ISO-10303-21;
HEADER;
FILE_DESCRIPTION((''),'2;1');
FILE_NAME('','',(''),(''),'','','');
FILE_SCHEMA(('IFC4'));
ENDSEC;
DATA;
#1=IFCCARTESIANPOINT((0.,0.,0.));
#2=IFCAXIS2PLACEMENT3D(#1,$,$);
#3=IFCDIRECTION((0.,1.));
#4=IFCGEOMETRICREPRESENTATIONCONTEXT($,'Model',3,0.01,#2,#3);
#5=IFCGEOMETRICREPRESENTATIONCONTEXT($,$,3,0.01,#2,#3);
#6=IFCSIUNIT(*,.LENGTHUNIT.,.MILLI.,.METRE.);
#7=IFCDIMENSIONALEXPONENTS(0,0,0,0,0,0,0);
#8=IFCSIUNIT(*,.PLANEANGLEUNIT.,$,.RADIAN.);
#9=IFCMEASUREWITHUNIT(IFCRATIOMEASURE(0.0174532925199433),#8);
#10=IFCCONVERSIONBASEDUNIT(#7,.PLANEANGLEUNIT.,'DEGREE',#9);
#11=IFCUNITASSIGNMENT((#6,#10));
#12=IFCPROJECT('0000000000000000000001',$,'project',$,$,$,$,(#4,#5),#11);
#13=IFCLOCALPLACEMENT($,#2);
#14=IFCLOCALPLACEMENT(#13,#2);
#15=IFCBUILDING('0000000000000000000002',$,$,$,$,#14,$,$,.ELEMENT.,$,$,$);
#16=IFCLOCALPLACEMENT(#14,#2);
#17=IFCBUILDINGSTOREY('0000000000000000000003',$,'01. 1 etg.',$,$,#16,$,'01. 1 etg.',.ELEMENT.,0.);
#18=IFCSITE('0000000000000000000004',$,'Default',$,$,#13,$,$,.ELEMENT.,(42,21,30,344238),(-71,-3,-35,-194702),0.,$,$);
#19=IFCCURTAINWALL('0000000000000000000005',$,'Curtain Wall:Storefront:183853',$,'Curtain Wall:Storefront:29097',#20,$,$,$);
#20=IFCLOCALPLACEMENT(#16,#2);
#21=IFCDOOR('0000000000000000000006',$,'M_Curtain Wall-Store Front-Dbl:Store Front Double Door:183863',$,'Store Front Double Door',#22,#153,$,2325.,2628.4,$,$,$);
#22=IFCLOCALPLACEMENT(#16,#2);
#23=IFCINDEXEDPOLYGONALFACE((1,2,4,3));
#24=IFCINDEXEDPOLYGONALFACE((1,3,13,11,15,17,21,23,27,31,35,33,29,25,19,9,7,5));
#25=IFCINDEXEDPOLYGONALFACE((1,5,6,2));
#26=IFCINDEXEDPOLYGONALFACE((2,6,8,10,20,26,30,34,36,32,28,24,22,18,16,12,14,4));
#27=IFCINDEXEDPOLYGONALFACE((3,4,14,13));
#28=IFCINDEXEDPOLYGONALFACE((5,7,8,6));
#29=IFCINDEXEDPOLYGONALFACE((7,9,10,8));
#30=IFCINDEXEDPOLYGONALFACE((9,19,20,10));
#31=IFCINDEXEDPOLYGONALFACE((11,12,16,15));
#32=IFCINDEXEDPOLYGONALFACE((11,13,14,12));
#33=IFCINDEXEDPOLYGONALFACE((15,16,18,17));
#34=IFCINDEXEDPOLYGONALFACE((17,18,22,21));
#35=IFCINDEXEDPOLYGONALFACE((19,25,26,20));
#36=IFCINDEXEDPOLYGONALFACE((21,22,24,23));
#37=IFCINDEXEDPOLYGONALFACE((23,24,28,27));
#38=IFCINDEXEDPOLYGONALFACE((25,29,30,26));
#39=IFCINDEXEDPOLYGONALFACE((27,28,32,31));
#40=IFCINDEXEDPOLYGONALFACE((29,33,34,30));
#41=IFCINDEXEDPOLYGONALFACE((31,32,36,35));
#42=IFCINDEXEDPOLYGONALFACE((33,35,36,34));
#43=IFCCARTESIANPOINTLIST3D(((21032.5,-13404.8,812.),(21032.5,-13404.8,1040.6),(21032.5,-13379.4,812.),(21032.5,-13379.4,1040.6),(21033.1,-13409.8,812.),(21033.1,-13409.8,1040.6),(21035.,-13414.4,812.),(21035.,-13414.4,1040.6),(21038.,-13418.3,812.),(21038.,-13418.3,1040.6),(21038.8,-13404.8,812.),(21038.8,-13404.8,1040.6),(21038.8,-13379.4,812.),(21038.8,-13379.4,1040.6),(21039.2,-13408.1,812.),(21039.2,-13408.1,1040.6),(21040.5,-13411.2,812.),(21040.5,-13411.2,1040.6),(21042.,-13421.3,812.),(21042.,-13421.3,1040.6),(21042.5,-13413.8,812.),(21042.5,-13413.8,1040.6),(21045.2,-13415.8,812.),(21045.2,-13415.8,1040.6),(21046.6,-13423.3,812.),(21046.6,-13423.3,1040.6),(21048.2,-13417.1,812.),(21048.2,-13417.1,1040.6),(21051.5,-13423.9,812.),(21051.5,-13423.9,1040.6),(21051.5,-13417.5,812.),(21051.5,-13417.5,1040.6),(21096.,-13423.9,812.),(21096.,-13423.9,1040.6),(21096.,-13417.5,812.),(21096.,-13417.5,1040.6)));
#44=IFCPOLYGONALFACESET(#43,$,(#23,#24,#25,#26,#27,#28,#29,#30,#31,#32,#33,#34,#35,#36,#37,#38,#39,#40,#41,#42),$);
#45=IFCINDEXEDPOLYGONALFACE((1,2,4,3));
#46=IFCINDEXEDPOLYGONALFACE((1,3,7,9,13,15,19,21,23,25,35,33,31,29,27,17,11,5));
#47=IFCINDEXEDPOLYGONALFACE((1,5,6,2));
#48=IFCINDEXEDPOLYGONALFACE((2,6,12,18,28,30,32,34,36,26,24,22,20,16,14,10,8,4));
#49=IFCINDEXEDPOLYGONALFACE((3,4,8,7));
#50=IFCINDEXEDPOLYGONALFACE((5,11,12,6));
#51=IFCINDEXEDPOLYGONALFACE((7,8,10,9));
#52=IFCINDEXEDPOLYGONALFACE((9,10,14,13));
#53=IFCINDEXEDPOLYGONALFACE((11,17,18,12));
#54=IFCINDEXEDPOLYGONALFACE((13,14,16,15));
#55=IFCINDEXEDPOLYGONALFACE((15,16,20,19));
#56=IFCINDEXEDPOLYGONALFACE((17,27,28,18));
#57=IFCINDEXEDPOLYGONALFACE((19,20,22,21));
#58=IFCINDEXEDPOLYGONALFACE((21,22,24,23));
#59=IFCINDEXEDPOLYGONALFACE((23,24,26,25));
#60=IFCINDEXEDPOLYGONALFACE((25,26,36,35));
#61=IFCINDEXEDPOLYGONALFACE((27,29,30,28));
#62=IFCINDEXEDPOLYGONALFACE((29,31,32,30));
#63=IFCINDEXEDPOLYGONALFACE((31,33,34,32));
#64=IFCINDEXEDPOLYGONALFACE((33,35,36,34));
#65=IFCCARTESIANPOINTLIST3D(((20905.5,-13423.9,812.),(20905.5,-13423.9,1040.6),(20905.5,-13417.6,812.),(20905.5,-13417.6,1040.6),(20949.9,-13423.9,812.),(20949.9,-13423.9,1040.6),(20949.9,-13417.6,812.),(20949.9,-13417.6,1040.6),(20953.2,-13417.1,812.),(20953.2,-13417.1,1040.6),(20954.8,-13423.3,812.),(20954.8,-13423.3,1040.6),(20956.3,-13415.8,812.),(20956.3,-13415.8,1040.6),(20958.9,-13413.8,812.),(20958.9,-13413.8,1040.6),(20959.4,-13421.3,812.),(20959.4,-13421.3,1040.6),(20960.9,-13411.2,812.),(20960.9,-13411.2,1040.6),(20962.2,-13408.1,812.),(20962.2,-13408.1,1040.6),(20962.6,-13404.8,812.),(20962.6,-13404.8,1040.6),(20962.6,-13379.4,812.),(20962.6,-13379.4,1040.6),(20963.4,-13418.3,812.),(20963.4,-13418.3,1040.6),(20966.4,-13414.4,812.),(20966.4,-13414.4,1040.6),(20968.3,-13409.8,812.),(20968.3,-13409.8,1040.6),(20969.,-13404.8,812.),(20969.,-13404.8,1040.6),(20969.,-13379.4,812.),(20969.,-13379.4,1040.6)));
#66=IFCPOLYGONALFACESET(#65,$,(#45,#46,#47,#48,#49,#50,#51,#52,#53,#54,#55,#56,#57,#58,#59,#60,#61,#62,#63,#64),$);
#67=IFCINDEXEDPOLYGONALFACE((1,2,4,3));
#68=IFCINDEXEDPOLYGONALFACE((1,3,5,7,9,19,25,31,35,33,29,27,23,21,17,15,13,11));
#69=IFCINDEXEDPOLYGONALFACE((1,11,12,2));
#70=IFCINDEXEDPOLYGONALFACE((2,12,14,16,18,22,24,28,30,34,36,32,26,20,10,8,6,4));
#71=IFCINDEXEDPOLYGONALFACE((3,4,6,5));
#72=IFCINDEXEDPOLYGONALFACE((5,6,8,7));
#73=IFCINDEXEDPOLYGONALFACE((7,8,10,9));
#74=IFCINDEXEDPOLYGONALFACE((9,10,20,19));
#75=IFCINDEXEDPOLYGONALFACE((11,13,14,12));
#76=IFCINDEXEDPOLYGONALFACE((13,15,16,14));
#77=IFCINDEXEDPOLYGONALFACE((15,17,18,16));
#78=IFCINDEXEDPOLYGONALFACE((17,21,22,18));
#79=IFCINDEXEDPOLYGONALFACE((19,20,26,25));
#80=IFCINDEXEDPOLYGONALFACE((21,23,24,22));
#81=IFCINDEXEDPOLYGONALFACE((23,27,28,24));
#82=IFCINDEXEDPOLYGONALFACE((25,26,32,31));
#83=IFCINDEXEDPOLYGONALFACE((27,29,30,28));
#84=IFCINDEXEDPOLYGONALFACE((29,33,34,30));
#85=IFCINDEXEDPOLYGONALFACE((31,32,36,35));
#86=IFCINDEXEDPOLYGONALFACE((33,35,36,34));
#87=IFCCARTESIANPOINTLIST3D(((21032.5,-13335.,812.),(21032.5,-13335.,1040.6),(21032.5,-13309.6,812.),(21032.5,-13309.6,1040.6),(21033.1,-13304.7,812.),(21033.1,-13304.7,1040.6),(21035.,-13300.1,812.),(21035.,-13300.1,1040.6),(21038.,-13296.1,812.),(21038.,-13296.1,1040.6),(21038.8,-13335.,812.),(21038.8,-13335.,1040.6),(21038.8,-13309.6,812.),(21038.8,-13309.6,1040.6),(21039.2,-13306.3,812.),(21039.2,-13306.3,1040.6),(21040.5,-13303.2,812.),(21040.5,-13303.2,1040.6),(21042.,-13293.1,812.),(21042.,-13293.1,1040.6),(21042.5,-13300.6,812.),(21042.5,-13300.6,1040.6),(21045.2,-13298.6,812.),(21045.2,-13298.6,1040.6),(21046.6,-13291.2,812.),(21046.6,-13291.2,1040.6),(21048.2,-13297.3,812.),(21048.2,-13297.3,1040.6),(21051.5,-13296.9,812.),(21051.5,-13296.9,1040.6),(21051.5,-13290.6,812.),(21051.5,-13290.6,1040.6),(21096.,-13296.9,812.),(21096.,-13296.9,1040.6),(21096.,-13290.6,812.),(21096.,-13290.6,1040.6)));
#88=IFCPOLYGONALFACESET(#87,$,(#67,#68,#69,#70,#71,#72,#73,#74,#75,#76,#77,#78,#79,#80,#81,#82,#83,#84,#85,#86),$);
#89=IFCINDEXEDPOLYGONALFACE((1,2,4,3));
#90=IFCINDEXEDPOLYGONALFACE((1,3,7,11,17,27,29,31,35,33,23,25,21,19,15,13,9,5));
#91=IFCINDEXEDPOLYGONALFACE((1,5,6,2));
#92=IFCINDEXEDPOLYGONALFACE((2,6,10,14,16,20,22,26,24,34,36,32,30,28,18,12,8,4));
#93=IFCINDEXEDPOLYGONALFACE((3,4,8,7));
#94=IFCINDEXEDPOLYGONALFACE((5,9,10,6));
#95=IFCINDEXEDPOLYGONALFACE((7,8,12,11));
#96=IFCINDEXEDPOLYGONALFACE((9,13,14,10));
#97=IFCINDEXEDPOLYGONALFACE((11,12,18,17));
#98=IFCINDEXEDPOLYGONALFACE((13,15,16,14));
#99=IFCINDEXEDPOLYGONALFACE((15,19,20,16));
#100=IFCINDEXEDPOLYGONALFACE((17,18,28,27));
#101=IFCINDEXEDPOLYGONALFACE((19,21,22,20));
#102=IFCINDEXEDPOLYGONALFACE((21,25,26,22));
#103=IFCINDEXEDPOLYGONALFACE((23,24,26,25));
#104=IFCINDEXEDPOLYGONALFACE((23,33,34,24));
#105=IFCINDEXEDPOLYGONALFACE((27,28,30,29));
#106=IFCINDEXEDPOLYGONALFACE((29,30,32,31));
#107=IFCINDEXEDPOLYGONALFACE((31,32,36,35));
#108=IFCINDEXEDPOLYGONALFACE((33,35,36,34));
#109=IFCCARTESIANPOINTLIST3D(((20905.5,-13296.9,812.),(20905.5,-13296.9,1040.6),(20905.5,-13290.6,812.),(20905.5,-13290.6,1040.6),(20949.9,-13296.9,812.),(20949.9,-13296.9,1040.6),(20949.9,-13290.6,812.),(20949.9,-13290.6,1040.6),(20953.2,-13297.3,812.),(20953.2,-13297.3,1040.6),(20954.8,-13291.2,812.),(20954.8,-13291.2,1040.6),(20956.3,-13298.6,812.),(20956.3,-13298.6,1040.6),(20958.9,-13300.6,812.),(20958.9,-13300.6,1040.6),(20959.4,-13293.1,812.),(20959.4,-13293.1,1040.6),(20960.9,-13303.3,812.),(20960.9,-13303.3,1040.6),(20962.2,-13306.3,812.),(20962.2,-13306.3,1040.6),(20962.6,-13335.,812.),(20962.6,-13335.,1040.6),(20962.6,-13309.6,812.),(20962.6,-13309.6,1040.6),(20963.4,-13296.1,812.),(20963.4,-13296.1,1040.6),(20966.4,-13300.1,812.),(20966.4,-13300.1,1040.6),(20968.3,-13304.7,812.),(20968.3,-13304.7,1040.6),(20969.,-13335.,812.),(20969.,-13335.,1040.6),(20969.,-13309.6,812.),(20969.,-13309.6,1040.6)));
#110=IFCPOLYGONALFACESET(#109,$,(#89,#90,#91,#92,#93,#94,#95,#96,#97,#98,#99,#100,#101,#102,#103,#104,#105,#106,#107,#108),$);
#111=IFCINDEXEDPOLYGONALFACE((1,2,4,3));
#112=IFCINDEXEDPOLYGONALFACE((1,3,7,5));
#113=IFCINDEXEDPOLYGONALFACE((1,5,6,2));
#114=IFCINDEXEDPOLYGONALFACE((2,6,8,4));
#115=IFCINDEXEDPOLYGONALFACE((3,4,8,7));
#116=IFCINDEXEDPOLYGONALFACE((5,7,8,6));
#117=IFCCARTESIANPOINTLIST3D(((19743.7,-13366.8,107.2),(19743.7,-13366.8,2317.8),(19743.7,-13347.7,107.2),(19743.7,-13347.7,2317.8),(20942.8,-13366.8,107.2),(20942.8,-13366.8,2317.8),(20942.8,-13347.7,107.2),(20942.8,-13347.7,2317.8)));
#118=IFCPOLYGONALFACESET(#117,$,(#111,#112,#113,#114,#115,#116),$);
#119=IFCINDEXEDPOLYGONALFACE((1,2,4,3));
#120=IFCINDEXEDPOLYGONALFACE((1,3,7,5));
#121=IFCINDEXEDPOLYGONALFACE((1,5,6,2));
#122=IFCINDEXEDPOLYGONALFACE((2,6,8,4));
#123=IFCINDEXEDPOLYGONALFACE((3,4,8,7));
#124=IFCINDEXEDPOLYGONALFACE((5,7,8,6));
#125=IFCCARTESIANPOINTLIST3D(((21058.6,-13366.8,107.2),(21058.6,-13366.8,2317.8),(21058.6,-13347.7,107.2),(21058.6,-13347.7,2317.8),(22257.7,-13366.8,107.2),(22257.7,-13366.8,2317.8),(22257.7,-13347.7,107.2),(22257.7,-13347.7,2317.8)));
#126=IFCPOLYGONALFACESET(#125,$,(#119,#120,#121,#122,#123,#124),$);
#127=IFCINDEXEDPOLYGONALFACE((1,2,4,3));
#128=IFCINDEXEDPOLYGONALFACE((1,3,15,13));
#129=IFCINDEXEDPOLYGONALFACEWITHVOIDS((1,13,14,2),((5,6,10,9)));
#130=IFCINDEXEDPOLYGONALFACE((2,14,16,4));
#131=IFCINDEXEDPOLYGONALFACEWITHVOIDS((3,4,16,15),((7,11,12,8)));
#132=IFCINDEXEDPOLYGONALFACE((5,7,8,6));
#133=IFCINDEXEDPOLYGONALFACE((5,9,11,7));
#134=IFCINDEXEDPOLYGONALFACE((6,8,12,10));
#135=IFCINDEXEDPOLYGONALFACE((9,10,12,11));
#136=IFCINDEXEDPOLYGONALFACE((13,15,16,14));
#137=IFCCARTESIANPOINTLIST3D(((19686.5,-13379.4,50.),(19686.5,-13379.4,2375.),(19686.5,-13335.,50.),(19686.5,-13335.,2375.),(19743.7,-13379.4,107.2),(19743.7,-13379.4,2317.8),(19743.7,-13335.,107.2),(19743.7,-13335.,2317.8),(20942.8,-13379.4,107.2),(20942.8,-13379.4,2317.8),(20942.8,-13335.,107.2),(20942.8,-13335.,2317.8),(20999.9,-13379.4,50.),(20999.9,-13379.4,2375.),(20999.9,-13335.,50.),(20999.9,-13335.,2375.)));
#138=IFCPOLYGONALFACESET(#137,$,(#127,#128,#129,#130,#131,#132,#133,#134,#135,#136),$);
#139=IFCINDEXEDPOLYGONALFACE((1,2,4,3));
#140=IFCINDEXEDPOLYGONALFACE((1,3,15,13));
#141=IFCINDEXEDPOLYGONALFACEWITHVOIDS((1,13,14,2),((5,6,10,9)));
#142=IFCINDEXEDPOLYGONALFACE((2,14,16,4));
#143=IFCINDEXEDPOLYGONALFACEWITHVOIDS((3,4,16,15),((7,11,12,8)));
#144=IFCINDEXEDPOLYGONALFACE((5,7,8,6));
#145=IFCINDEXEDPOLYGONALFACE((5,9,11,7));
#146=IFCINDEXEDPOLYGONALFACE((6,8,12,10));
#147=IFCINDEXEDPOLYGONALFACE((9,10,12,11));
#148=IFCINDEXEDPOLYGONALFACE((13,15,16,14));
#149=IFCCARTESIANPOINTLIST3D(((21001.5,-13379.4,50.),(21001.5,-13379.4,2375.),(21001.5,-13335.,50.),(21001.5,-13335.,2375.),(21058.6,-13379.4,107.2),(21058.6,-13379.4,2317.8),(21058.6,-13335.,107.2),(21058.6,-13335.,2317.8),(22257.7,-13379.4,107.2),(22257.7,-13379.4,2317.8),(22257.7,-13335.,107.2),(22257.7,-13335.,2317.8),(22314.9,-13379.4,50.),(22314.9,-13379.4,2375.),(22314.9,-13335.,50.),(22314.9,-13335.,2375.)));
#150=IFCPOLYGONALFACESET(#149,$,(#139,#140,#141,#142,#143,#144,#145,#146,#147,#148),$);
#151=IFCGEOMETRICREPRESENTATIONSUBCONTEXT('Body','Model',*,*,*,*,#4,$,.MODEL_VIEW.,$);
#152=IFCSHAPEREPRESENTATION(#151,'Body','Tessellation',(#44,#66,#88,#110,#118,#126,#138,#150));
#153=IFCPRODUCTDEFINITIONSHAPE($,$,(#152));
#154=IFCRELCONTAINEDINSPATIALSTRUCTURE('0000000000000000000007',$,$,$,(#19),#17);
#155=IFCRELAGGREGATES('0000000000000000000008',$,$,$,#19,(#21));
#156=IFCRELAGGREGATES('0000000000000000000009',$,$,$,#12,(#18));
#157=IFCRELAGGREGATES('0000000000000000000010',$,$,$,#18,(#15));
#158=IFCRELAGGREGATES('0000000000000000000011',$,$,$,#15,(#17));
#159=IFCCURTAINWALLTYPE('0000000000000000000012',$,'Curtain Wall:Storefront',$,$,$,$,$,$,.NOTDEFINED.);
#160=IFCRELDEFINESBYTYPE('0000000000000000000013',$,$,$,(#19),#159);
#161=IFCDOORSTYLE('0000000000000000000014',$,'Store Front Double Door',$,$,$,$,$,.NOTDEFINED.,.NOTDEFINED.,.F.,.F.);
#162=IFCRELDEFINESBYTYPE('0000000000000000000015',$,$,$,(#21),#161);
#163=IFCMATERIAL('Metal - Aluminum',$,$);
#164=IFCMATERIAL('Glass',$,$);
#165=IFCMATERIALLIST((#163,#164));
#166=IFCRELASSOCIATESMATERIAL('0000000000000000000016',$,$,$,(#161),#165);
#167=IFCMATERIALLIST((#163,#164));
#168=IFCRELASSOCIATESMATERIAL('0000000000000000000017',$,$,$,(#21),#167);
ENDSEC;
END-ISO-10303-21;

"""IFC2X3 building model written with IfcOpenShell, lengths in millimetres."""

from ifc_helpers import new_model, entity, si_unit, converted_unit, direction, frame, frame_2d, origin, place, context, subcontext, project, spatial, polyline, circle_curve, parameter, trimmed, segment, composite_curve, rectangle, outline, extrude, source, transform, mapped, material, material_list, type_object, type_shapes, element, aggregate, save


model = new_model("IFC2X3")

# Units and contexts
model_context = context("Model", 3, precision=0.01, world=origin(), true_north=direction((0.0, 1.0)))
context_of_model = context(None, 3, precision=0.01, world=origin(), true_north=direction((0.0, 1.0)))
body_context = subcontext(model_context, "Body", "Model", "MODEL_VIEW")
ifc_project = project(units=[si_unit("LENGTHUNIT", "METRE", prefix="MILLI"), converted_unit("PLANEANGLEUNIT", "DEGREE", entity("IfcRatioMeasure", 0.0174532925199433), si_unit("PLANEANGLEUNIT", "RADIAN"), dimensions=[0, 0, 0, 0, 0, 0, 0])], contexts=[model_context, context_of_model])

# Site, building, storey
site_placement = place(None, origin())
site = spatial("IfcSite", under=ifc_project, at=site_placement, Name="Default", CompositionType="ELEMENT", RefLatitude=(42, 21, 30, 344238), RefLongitude=(-71, -3, -35, -194702), RefElevation=0.0)
building_placement = place(site_placement, origin())
building = spatial("IfcBuilding", under=site, at=building_placement, CompositionType="ELEMENT")
storey_placement = place(building_placement, origin())
storey = spatial("IfcBuildingStorey", under=building, at=storey_placement, Name="01. 1 etg.", LongName="01. 1 etg.", CompositionType="ELEMENT", Elevation=0.0)

# Curtain wall, door
curtain_wall_type = type_object("IfcCurtainWallType", Name="Curtain Wall:Storefront", PredefinedType="NOTDEFINED")
curtain_wall_placement = place(storey_placement, origin())
curtain_wall = element("IfcCurtainWall", 1, at=curtain_wall_placement, inside=storey, type_object=curtain_wall_type, Name="Curtain Wall:Storefront:183853", ObjectType="Curtain Wall:Storefront:29097")
ifc_material_1 = material(Name="Glass")
ifc_material_2 = material(Name="Metal - Aluminum")
ifc_material_list_1 = material_list([ifc_material_2, ifc_material_1])
ifc_material_list_2 = material_list([ifc_material_2, ifc_material_1])
door_style = type_object("IfcDoorStyle", Name="Store Front Double Door", ConstructionType="NOTDEFINED", OperationType="NOTDEFINED", ParameterTakesPrecedence=False, Sizeable=False, material=ifc_material_list_2)
shared_shape_1 = source(origin(), body_context, "Body", "SweptSolid", [
    extrude(outline(composite_curve([segment(trimmed(circle_curve(frame_2d((-3.2, 1.6), x_axis=(1.0, 0.0)), 19.0), [parameter(180.0)], [parameter(270.0)], True, "PARAMETER"), True, "CONTINUOUS"), segment(polyline([(-3.2, -17.5), (41.3, -17.5)]), True, "CONTINUOUS"), segment(polyline([(41.3, -17.5), (41.3, -11.1)]), True, "CONTINUOUS"), segment(polyline([(41.3, -11.1), (-3.2, -11.1)]), True, "CONTINUOUS"), segment(trimmed(circle_curve(frame_2d((-3.2, 1.6), x_axis=(1.0, 0.0)), 12.7), [parameter(180.0)], [parameter(270.0)], True, "PARAMETER"), False, "CONTINUOUS"), segment(polyline([(-15.9, 1.6), (-15.9, 27.0)]), True, "CONTINUOUS"), segment(polyline([(-15.9, 27.0), (-22.2, 27.0)]), True, "CONTINUOUS"), segment(polyline([(-22.2, 27.0), (-22.2, 1.6)]), True, "CONTINUOUS")], self_intersect=False)), frame((54.0, -16.4, 762.0)), (0.0, 0.0, 1.0), 228.6),
    extrude(outline(composite_curve([segment(polyline([(1.6, -22.2), (27.0, -22.2)]), True, "CONTINUOUS"), segment(polyline([(27.0, -22.2), (27.0, -15.9)]), True, "CONTINUOUS"), segment(polyline([(27.0, -15.9), (1.6, -15.9)]), True, "CONTINUOUS"), segment(trimmed(circle_curve(frame_2d((1.6, -3.2), x_axis=(0.0, -1.0)), 12.7), [parameter(270.0)], [parameter(0.0)], True, "PARAMETER"), False, "CONTINUOUS"), segment(polyline([(-11.1, -3.2), (-11.1, 41.3)]), True, "CONTINUOUS"), segment(polyline([(-11.1, 41.3), (-17.5, 41.3)]), True, "CONTINUOUS"), segment(polyline([(-17.5, 41.3), (-17.5, -3.2)]), True, "CONTINUOUS"), segment(trimmed(circle_curve(frame_2d((1.6, -3.2), x_axis=(0.0, -1.0)), 19.1), [parameter(270.0)], [parameter(360.0)], True, "PARAMETER"), True, "CONTINUOUS")], self_intersect=False)), frame((-54.0, -16.4, 762.0), z_axis=(0.0, 0.0, 1.0), x_axis=(0.0, 1.0, 0.0)), (0.0, 0.0, 1.0), 228.6),
    extrude(outline(composite_curve([segment(polyline([(1.6, -22.2), (27.0, -22.2)]), True, "CONTINUOUS"), segment(polyline([(27.0, -22.2), (27.0, -15.9)]), True, "CONTINUOUS"), segment(polyline([(27.0, -15.9), (1.6, -15.9)]), True, "CONTINUOUS"), segment(trimmed(circle_curve(frame_2d((1.6, -3.2), x_axis=(0.0, 1.0)), 12.7), [parameter(90.0)], [parameter(180.0)], True, "PARAMETER"), False, "CONTINUOUS"), segment(polyline([(-11.1, -3.2), (-11.1, 41.3)]), True, "CONTINUOUS"), segment(polyline([(-11.1, 41.3), (-17.5, 41.3)]), True, "CONTINUOUS"), segment(polyline([(-17.5, 41.3), (-17.5, -3.2)]), True, "CONTINUOUS"), segment(trimmed(circle_curve(frame_2d((1.6, -3.2), x_axis=(0.0, 1.0)), 19.1), [parameter(90.0)], [parameter(180.0)], True, "PARAMETER"), True, "CONTINUOUS")], self_intersect=False)), frame((54.0, 82.0, 762.0), z_axis=(0.0, 0.0, 1.0), x_axis=(0.0, -1.0, 0.0)), (0.0, 0.0, 1.0), 228.6),
    extrude(outline(composite_curve([segment(trimmed(circle_curve(frame_2d((3.2, -1.6), x_axis=(1.0, 0.0)), 19.0), [parameter(0.0)], [parameter(90.0)], True, "PARAMETER"), True, "CONTINUOUS"), segment(polyline([(3.2, 17.5), (-41.3, 17.5)]), True, "CONTINUOUS"), segment(polyline([(-41.3, 17.5), (-41.3, 11.1)]), True, "CONTINUOUS"), segment(polyline([(-41.3, 11.1), (3.2, 11.1)]), True, "CONTINUOUS"), segment(trimmed(circle_curve(frame_2d((3.2, -1.6), x_axis=(1.0, 0.0)), 12.7), [parameter(0.0)], [parameter(90.0)], True, "PARAMETER"), False, "CONTINUOUS"), segment(polyline([(15.9, -1.6), (15.9, -27.0)]), True, "CONTINUOUS"), segment(polyline([(15.9, -27.0), (22.2, -27.0)]), True, "CONTINUOUS"), segment(polyline([(22.2, -27.0), (22.2, -1.6)]), True, "CONTINUOUS")], self_intersect=False)), frame((-54.0, 82.0, 762.0)), (0.0, 0.0, 1.0), 228.6),
    extrude(rectangle(XDim=19.0, YDim=1199.1, at=frame_2d((0.0, 0.0), x_axis=(1.0, 0.0))), frame((-657.5, 32.8, 57.1), z_axis=(0.0, 0.0, 1.0), x_axis=(0.0, 1.0, 0.0)), (0.0, 0.0, 1.0), 2210.7),
    extrude(rectangle(XDim=19.0, YDim=1199.1, at=frame_2d((0.0, 0.0), x_axis=(1.0, 0.0))), frame((657.5, 32.8, 57.1), z_axis=(0.0, 0.0, 1.0), x_axis=(0.0, 1.0, 0.0)), (0.0, 0.0, 1.0), 2210.7),
    extrude(outline(polyline([(-1162.5, -656.7), (1162.5, -656.7), (1162.5, 656.7), (-1162.5, 656.7), (-1162.5, -656.7)]), holes=[polyline([(-1105.3, 599.5), (1105.3, 599.5), (1105.3, -599.5), (-1105.3, -599.5), (-1105.3, 599.5)])]), frame((-657.5, 10.5, 1162.5), z_axis=(0.0, 1.0, 0.0), x_axis=(0.0, 0.0, -1.0)), (0.0, 0.0, 1.0), 44.5),
    extrude(outline(polyline([(-656.7, -1162.5), (656.7, -1162.5), (656.7, 1162.5), (-656.7, 1162.5), (-656.7, -1162.5)]), holes=[polyline([(-599.5, -1105.3), (-599.5, 1105.3), (599.5, 1105.3), (599.5, -1105.3), (-599.5, -1105.3)])]), frame((657.5, 10.5, 1162.5), z_axis=(0.0, 1.0, 0.0), x_axis=(1.0, 0.0, 0.0)), (0.0, 0.0, 1.0), 44.5),
])
type_shapes(door_style, [shared_shape_1])
door_placement = place(curtain_wall_placement, frame((21000.7, -13390.0, 50.0)))
door = element("IfcDoor", 2, at=door_placement, type_object=door_style, material=ifc_material_list_1, Name="M_Curtain Wall-Store Front-Dbl:Store Front Double Door:183863", ObjectType="Store Front Double Door", OverallHeight=2325.0, OverallWidth=2628.4, context=body_context, shape_type="MappedRepresentation", body=[
    mapped(shared_shape_1, transform((0.0, 0.0, 0.0), scale=1.0)),
])
aggregate(curtain_wall, [door])

save(model, "model.ifc")
